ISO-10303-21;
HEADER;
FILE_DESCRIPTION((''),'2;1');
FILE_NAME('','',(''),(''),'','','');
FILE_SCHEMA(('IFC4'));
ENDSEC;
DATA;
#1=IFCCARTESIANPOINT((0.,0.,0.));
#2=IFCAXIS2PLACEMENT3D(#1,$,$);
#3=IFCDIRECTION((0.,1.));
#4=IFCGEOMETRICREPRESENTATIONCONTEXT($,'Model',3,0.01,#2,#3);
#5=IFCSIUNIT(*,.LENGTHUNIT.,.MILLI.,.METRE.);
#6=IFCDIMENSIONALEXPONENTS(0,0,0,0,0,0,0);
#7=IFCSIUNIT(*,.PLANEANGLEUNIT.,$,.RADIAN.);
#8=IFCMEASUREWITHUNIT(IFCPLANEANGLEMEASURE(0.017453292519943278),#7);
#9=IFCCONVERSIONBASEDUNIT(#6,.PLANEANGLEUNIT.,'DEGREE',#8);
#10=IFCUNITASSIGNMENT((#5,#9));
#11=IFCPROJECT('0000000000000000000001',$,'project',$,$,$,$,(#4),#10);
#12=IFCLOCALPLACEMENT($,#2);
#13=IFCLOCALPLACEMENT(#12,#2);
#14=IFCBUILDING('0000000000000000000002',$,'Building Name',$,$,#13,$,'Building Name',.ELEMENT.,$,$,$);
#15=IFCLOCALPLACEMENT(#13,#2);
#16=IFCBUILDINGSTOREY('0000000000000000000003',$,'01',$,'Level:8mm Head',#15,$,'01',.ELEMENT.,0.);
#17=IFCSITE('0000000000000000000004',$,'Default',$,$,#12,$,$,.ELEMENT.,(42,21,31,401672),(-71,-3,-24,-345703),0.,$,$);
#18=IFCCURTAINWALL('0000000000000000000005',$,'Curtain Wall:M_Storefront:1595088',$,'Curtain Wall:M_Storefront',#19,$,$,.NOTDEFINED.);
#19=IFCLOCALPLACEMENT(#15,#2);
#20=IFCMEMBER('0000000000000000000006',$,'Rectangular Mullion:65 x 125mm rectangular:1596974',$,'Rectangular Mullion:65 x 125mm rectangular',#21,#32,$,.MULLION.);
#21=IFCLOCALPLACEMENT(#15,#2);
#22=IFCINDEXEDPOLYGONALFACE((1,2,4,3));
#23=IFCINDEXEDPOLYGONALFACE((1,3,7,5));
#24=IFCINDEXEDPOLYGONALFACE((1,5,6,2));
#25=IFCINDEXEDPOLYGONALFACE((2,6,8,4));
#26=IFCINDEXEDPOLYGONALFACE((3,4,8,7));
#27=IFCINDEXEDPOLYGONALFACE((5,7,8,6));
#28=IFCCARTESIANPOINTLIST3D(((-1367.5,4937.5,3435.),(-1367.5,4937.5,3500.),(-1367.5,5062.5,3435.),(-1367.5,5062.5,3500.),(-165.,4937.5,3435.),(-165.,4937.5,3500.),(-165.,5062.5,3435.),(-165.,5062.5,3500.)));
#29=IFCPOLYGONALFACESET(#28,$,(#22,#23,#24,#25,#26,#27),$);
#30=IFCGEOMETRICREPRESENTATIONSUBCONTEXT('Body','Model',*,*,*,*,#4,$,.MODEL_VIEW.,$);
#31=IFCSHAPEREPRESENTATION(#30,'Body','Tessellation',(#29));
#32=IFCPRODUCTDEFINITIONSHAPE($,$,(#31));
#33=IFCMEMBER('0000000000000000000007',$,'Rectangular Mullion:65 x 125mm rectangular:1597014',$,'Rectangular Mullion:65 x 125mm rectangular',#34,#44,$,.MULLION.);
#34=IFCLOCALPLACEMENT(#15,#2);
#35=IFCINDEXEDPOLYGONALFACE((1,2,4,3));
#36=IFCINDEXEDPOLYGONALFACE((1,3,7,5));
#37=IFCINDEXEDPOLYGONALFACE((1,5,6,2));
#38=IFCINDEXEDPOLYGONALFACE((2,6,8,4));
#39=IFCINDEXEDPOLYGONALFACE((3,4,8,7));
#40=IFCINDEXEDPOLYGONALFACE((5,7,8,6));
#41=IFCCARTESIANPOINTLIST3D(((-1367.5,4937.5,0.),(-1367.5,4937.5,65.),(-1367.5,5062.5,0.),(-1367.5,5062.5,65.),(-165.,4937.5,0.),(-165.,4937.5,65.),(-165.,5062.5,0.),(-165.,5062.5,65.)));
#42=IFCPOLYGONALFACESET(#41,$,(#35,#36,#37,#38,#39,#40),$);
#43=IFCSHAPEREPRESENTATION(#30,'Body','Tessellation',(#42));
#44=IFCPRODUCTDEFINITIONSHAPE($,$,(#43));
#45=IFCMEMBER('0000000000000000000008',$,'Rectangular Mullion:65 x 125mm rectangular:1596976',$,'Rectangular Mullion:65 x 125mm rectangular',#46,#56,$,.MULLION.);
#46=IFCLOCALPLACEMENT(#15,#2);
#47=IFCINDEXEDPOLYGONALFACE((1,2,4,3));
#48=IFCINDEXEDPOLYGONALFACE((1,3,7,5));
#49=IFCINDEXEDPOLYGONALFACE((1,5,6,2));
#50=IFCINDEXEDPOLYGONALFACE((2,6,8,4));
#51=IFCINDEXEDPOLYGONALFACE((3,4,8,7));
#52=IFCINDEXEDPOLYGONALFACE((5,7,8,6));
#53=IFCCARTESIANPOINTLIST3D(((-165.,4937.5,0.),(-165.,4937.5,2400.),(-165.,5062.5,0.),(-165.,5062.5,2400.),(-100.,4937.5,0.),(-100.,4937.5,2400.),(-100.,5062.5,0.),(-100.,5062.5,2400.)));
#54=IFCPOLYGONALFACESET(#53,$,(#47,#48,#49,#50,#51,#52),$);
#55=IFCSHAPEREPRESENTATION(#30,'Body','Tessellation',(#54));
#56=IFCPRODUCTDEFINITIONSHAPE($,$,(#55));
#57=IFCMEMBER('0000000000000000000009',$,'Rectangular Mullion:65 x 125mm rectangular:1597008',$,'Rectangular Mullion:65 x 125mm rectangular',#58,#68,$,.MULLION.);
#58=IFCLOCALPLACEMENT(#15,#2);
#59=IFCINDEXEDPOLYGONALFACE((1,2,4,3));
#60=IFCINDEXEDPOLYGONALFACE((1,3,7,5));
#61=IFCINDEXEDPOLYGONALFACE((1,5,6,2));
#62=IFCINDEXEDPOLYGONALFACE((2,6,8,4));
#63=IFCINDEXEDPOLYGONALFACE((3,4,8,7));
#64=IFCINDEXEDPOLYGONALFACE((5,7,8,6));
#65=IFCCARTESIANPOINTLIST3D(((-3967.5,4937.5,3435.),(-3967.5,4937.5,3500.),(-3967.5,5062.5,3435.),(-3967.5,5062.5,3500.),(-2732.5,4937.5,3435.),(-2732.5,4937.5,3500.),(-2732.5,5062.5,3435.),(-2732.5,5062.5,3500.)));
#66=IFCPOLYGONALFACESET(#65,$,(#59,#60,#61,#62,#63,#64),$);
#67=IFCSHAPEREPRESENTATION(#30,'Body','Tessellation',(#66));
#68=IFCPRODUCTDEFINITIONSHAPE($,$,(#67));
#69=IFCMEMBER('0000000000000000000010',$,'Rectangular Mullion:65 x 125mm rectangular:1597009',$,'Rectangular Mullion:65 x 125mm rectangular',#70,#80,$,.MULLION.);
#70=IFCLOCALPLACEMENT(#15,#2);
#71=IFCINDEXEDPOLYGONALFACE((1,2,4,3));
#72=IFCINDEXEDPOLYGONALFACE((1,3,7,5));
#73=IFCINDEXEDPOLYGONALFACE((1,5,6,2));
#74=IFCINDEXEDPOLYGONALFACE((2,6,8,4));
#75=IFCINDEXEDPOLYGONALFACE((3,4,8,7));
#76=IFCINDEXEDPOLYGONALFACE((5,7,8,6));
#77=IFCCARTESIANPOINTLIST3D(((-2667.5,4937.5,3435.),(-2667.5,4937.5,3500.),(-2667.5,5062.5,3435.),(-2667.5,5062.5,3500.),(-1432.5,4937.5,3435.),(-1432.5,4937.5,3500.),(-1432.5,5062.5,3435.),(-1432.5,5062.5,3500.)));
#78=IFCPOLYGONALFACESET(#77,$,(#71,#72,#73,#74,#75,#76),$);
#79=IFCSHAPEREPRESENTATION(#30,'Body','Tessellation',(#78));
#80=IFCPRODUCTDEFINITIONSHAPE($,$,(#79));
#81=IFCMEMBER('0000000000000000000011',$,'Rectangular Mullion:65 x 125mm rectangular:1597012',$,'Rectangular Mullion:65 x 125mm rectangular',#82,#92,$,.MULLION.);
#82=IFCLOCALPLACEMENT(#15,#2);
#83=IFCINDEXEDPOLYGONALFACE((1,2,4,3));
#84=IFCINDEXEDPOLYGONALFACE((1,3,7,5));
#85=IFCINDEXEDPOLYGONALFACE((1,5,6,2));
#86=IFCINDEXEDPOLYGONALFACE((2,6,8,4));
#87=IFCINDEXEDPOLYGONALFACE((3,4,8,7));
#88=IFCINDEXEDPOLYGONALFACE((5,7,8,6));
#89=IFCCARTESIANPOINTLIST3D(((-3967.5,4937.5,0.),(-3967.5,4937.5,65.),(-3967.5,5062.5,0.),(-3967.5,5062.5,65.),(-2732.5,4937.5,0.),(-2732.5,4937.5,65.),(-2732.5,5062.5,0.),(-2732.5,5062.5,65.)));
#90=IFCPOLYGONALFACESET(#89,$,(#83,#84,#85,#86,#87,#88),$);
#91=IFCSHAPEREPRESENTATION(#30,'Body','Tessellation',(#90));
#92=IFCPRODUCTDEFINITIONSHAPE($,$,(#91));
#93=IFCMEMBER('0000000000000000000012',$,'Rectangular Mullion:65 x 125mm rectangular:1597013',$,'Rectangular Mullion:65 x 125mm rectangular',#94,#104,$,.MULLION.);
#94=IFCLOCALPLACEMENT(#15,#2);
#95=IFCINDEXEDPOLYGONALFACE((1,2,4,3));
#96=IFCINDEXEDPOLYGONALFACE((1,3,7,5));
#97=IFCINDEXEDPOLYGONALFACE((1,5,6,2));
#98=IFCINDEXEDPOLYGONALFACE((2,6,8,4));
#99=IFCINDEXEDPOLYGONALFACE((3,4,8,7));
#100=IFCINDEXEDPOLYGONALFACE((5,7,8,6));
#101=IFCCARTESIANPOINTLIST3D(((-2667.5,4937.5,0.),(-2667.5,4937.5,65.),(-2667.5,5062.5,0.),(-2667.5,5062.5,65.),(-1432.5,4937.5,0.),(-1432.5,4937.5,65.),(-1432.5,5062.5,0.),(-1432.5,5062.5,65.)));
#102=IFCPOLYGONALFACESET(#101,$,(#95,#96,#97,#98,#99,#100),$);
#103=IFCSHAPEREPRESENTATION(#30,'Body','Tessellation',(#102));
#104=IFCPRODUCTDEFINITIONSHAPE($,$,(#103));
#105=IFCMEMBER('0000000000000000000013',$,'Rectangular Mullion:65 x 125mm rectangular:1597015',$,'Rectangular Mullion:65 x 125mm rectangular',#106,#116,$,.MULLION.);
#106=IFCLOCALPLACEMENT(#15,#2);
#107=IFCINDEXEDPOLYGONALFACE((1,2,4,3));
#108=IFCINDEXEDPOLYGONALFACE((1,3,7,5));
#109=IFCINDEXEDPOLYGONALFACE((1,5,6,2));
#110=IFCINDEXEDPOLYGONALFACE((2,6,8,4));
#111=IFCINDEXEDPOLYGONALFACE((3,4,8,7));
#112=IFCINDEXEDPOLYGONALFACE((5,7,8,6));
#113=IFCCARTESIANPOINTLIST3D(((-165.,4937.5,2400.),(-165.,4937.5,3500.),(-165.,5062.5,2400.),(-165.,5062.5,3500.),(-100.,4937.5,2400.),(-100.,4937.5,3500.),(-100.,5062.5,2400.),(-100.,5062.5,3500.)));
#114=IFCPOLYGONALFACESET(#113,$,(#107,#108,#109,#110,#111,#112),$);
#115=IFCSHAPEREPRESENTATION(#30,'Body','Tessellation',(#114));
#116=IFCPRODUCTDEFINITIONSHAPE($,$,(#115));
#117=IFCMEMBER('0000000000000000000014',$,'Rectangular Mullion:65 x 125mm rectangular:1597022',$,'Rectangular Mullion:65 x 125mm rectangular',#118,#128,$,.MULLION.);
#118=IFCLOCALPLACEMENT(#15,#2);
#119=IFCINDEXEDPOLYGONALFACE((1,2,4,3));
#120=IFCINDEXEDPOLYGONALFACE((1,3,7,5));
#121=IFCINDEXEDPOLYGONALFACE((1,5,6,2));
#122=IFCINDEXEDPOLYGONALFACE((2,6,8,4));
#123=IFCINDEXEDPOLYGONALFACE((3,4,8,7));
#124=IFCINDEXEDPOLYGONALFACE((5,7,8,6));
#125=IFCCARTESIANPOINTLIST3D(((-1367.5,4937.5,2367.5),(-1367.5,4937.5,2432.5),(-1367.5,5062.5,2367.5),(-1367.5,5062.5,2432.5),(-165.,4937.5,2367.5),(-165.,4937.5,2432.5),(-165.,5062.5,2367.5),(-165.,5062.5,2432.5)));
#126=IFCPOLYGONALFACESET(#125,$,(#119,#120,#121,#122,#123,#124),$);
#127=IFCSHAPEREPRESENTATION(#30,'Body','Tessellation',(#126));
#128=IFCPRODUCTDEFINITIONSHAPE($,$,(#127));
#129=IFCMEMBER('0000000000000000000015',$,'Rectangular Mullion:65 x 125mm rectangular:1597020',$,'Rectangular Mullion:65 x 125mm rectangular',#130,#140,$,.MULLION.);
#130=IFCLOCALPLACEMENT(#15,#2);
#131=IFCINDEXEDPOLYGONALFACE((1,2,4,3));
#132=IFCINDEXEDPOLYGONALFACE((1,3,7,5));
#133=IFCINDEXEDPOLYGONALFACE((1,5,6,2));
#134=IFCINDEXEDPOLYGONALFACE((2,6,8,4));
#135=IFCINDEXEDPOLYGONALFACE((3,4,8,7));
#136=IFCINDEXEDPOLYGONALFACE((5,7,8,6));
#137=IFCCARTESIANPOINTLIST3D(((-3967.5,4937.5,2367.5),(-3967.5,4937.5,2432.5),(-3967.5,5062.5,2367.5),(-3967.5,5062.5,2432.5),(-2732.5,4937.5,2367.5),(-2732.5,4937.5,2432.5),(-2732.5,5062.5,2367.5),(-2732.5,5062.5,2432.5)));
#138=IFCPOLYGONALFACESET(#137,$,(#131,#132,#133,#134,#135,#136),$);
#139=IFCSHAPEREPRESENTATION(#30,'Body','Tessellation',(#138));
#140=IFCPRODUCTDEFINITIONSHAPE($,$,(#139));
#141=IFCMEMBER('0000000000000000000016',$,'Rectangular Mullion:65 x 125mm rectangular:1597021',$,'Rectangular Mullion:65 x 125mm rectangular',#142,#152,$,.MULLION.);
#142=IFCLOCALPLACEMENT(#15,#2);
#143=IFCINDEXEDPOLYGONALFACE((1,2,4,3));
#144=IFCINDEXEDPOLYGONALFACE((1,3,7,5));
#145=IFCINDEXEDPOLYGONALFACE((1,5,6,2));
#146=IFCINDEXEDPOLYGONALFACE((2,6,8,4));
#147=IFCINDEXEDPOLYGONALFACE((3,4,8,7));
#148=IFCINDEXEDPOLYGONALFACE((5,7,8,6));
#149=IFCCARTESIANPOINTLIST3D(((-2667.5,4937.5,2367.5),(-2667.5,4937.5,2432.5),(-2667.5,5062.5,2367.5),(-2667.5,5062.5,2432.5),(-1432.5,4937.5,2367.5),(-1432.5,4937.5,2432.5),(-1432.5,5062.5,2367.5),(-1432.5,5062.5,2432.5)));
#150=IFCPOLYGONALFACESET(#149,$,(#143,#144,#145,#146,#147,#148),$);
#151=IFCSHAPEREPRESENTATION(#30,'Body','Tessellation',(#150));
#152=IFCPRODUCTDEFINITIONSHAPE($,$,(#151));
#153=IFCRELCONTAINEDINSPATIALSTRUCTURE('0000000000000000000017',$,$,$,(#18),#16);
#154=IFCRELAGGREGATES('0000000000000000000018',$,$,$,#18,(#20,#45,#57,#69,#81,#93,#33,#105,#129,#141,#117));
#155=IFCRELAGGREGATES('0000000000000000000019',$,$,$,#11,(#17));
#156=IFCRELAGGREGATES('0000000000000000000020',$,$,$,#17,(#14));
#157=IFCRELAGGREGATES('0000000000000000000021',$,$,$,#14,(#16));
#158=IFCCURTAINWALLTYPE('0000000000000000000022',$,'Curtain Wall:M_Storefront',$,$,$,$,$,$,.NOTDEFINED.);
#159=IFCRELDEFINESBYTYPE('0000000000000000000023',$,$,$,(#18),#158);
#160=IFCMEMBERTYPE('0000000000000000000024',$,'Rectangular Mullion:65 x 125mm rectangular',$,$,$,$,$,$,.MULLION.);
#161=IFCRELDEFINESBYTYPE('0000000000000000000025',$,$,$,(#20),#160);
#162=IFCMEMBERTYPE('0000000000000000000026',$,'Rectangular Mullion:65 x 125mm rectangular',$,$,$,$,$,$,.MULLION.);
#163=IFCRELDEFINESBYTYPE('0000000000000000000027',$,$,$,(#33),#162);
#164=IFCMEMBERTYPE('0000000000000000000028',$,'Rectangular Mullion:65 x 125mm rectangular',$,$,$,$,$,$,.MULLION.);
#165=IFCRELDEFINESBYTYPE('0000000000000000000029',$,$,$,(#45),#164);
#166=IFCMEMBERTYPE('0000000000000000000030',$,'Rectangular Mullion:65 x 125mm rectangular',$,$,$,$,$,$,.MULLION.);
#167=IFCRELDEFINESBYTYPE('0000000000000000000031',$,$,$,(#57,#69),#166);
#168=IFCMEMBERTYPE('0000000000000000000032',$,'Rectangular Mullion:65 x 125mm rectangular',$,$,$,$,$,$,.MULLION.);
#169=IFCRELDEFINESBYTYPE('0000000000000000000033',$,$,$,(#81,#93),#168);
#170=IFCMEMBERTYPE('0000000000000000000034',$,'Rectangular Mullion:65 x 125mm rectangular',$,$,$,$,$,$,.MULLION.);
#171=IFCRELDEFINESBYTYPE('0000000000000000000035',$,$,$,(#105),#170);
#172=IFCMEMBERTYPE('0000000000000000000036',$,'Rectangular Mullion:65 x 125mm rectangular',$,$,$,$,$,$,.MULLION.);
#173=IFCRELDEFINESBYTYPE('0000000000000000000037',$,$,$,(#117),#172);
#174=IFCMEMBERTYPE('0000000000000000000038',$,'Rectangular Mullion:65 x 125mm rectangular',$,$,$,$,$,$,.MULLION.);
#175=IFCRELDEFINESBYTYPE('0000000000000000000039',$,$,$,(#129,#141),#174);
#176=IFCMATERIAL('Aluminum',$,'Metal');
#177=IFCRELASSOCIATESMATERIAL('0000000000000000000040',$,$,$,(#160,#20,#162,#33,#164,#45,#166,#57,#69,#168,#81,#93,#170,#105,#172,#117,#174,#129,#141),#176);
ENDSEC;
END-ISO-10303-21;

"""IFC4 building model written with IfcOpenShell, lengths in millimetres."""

from ifc_helpers import new_model, entity, si_unit, converted_unit, direction, frame, origin, place, context, subcontext, project, spatial, indexed_curve, outline, extrude, source, transform, mapped, material, type_object, type_shapes, element, aggregate, save


model = new_model("IFC4")

# Units and contexts
model_context = context("Model", 3, precision=0.01, world=origin(), true_north=direction((0.0, 1.0)))
body_context = subcontext(model_context, "Body", "Model", "MODEL_VIEW")
ifc_project = project(units=[si_unit("LENGTHUNIT", "METRE", prefix="MILLI"), converted_unit("PLANEANGLEUNIT", "DEGREE", entity("IfcPlaneAngleMeasure", 0.017453292519943278), si_unit("PLANEANGLEUNIT", "RADIAN"), dimensions=[0, 0, 0, 0, 0, 0, 0])], contexts=[model_context])

# Site, building, storey
site_placement = place(None, origin())
site = spatial("IfcSite", under=ifc_project, at=site_placement, Name="Default", CompositionType="ELEMENT", RefLatitude=(42, 21, 31, 401672), RefLongitude=(-71, -3, -24, -345703), RefElevation=0.0)
building_placement = place(site_placement, origin())
building = spatial("IfcBuilding", under=site, at=building_placement, Name="Building Name", LongName="Building Name", CompositionType="ELEMENT")
storey_placement = place(building_placement, origin())
storey = spatial("IfcBuildingStorey", under=building, at=storey_placement, Name="01", ObjectType="Level:8mm Head", LongName="01", CompositionType="ELEMENT", Elevation=0.0)

# Curtain wall, members
curtain_wall_type = type_object("IfcCurtainWallType", Name="Curtain Wall:M_Storefront", PredefinedType="NOTDEFINED")
curtain_wall_placement = place(storey_placement, origin())
curtain_wall = element("IfcCurtainWall", 1, at=curtain_wall_placement, inside=storey, type_object=curtain_wall_type, Name="Curtain Wall:M_Storefront:1595088", ObjectType="Curtain Wall:M_Storefront", PredefinedType="NOTDEFINED")
ifc_material_1 = material(Name="Aluminum", Category="Metal")
member_type_1 = type_object("IfcMemberType", Name="Rectangular Mullion:65 x 125mm rectangular", PredefinedType="MULLION", material=ifc_material_1)
shared_shape_1 = source(origin(), body_context, "Body", "SweptSolid", [
    extrude(outline(indexed_curve([(-32.5, -62.5), (32.5, -62.5), (32.5, 62.5), (-32.5, 62.5), (-32.5, -62.5)], self_intersect=False)), frame((-32.5, 0.0, -1202.5), z_axis=(0.0, 0.0, 1.0), x_axis=(-1.0, 0.0, 0.0)), (0.0, 0.0, 1.0), 1202.5),
])
type_shapes(member_type_1, [shared_shape_1])
member_1_placement = place(curtain_wall_placement, frame((-165.0, 5000.0, 3500.0), z_axis=(1.0, 0.0, 0.0), x_axis=(0.0, 0.0, 1.0)))
member_1 = element("IfcMember", 2, at=member_1_placement, type_object=member_type_1, material=ifc_material_1, Name="Rectangular Mullion:65 x 125mm rectangular:1596974", ObjectType="Rectangular Mullion:65 x 125mm rectangular", PredefinedType="MULLION", context=body_context, shape_type="MappedRepresentation", body=[
    mapped(shared_shape_1, transform((0.0, 0.0, 0.0), scale=1.0)),
])
member_type_2 = type_object("IfcMemberType", Name="Rectangular Mullion:65 x 125mm rectangular", PredefinedType="MULLION", material=ifc_material_1)
shared_shape_2 = source(origin(), body_context, "Body", "SweptSolid", [
    extrude(outline(indexed_curve([(-32.5, -62.5), (32.5, -62.5), (32.5, 62.5), (-32.5, 62.5), (-32.5, -62.5)], self_intersect=False)), frame((-32.5, 0.0, -1202.5), z_axis=(0.0, 0.0, 1.0), x_axis=(-1.0, 0.0, 0.0)), (0.0, 0.0, 1.0), 1202.5),
])
type_shapes(member_type_2, [shared_shape_2])
member_2_placement = place(curtain_wall_placement, frame((-1367.5, 5000.0, 0.0), z_axis=(-1.0, 0.0, 0.0), x_axis=(0.0, 0.0, -1.0)))
member_2 = element("IfcMember", 3, at=member_2_placement, type_object=member_type_2, material=ifc_material_1, Name="Rectangular Mullion:65 x 125mm rectangular:1597014", ObjectType="Rectangular Mullion:65 x 125mm rectangular", PredefinedType="MULLION", context=body_context, shape_type="MappedRepresentation", body=[
    mapped(shared_shape_2, transform((0.0, 0.0, 0.0), scale=1.0)),
])
member_type_3 = type_object("IfcMemberType", Name="Rectangular Mullion:65 x 125mm rectangular", PredefinedType="MULLION", material=ifc_material_1)
shared_shape_3 = source(origin(), body_context, "Body", "SweptSolid", [
    extrude(outline(indexed_curve([(-32.5, -62.5), (32.5, -62.5), (32.5, 62.5), (-32.5, 62.5), (-32.5, -62.5)], self_intersect=False)), frame((-32.5, 0.0, -2400.0), z_axis=(0.0, 0.0, 1.0), x_axis=(-1.0, 0.0, 0.0)), (0.0, 0.0, 1.0), 2400.0),
])
type_shapes(member_type_3, [shared_shape_3])
member_3_placement = place(curtain_wall_placement, frame((-100.0, 5000.0, 0.0), z_axis=(0.0, 0.0, -1.0), x_axis=(1.0, 0.0, 0.0)))
member_3 = element("IfcMember", 4, at=member_3_placement, type_object=member_type_3, material=ifc_material_1, Name="Rectangular Mullion:65 x 125mm rectangular:1596976", ObjectType="Rectangular Mullion:65 x 125mm rectangular", PredefinedType="MULLION", context=body_context, shape_type="MappedRepresentation", body=[
    mapped(shared_shape_3, transform((0.0, 0.0, 0.0), scale=1.0)),
])
member_type_4 = type_object("IfcMemberType", Name="Rectangular Mullion:65 x 125mm rectangular", PredefinedType="MULLION", material=ifc_material_1)
shared_shape_4 = source(origin(), body_context, "Body", "SweptSolid", [
    extrude(outline(indexed_curve([(-32.5, -62.5), (32.5, -62.5), (32.5, 62.5), (-32.5, 62.5), (-32.5, -62.5)], self_intersect=False)), frame((-32.5, 0.0, -1235.0), z_axis=(0.0, 0.0, 1.0), x_axis=(-1.0, 0.0, 0.0)), (0.0, 0.0, 1.0), 1235.0),
])
type_shapes(member_type_4, [shared_shape_4])
member_4_placement = place(curtain_wall_placement, frame((-2732.5, 5000.0, 3500.0), z_axis=(1.0, 0.0, 0.0), x_axis=(0.0, 0.0, 1.0)))
member_4 = element("IfcMember", 5, at=member_4_placement, type_object=member_type_4, material=ifc_material_1, Name="Rectangular Mullion:65 x 125mm rectangular:1597008", ObjectType="Rectangular Mullion:65 x 125mm rectangular", PredefinedType="MULLION", context=body_context, shape_type="MappedRepresentation", body=[
    mapped(shared_shape_4, transform((0.0, 0.0, 0.0), scale=1.0)),
])
member_5_placement = place(curtain_wall_placement, frame((-1432.5, 5000.0, 3500.0), z_axis=(1.0, 0.0, 0.0), x_axis=(0.0, 0.0, 1.0)))
member_5 = element("IfcMember", 6, at=member_5_placement, type_object=member_type_4, material=ifc_material_1, Name="Rectangular Mullion:65 x 125mm rectangular:1597009", ObjectType="Rectangular Mullion:65 x 125mm rectangular", PredefinedType="MULLION", context=body_context, shape_type="MappedRepresentation", body=[
    mapped(shared_shape_4, transform((0.0, 0.0, 0.0), scale=1.0)),
])
member_type_5 = type_object("IfcMemberType", Name="Rectangular Mullion:65 x 125mm rectangular", PredefinedType="MULLION", material=ifc_material_1)
shared_shape_5 = source(origin(), body_context, "Body", "SweptSolid", [
    extrude(outline(indexed_curve([(-32.5, -62.5), (32.5, -62.5), (32.5, 62.5), (-32.5, 62.5), (-32.5, -62.5)], self_intersect=False)), frame((-32.5, 0.0, -1235.0), z_axis=(0.0, 0.0, 1.0), x_axis=(-1.0, 0.0, 0.0)), (0.0, 0.0, 1.0), 1235.0),
])
type_shapes(member_type_5, [shared_shape_5])
member_6_placement = place(curtain_wall_placement, frame((-3967.5, 5000.0, 0.0), z_axis=(-1.0, 0.0, 0.0), x_axis=(0.0, 0.0, -1.0)))
member_6 = element("IfcMember", 7, at=member_6_placement, type_object=member_type_5, material=ifc_material_1, Name="Rectangular Mullion:65 x 125mm rectangular:1597012", ObjectType="Rectangular Mullion:65 x 125mm rectangular", PredefinedType="MULLION", context=body_context, shape_type="MappedRepresentation", body=[
    mapped(shared_shape_5, transform((0.0, 0.0, 0.0), scale=1.0)),
])
member_7_placement = place(curtain_wall_placement, frame((-2667.5, 5000.0, 0.0), z_axis=(-1.0, 0.0, 0.0), x_axis=(0.0, 0.0, -1.0)))
member_7 = element("IfcMember", 8, at=member_7_placement, type_object=member_type_5, material=ifc_material_1, Name="Rectangular Mullion:65 x 125mm rectangular:1597013", ObjectType="Rectangular Mullion:65 x 125mm rectangular", PredefinedType="MULLION", context=body_context, shape_type="MappedRepresentation", body=[
    mapped(shared_shape_5, transform((0.0, 0.0, 0.0), scale=1.0)),
])
member_type_6 = type_object("IfcMemberType", Name="Rectangular Mullion:65 x 125mm rectangular", PredefinedType="MULLION", material=ifc_material_1)
shared_shape_6 = source(origin(), body_context, "Body", "SweptSolid", [
    extrude(outline(indexed_curve([(-32.5, -62.5), (32.5, -62.5), (32.5, 62.5), (-32.5, 62.5), (-32.5, -62.5)], self_intersect=False)), frame((-32.5, 0.0, -1100.0), z_axis=(0.0, 0.0, 1.0), x_axis=(-1.0, 0.0, 0.0)), (0.0, 0.0, 1.0), 1100.0),
])
type_shapes(member_type_6, [shared_shape_6])
member_8_placement = place(curtain_wall_placement, frame((-100.0, 5000.0, 2400.0), z_axis=(0.0, 0.0, -1.0), x_axis=(1.0, 0.0, 0.0)))
member_8 = element("IfcMember", 9, at=member_8_placement, type_object=member_type_6, material=ifc_material_1, Name="Rectangular Mullion:65 x 125mm rectangular:1597015", ObjectType="Rectangular Mullion:65 x 125mm rectangular", PredefinedType="MULLION", context=body_context, shape_type="MappedRepresentation", body=[
    mapped(shared_shape_6, transform((0.0, 0.0, 0.0), scale=1.0)),
])
member_type_7 = type_object("IfcMemberType", Name="Rectangular Mullion:65 x 125mm rectangular", PredefinedType="MULLION", material=ifc_material_1)
shared_shape_7 = source(origin(), body_context, "Body", "SweptSolid", [
    extrude(outline(indexed_curve([(-32.5, -62.5), (32.5, -62.5), (32.5, 62.5), (-32.5, 62.5), (-32.5, -62.5)], self_intersect=False)), frame((0.0, 0.0, -1202.5), z_axis=(0.0, 0.0, 1.0), x_axis=(-1.0, 0.0, 0.0)), (0.0, 0.0, 1.0), 1202.5),
])
type_shapes(member_type_7, [shared_shape_7])
member_9_placement = place(curtain_wall_placement, frame((-165.0, 5000.0, 2400.0), z_axis=(1.0, 0.0, 0.0), x_axis=(0.0, 0.0, 1.0)))
member_9 = element("IfcMember", 10, at=member_9_placement, type_object=member_type_7, material=ifc_material_1, Name="Rectangular Mullion:65 x 125mm rectangular:1597022", ObjectType="Rectangular Mullion:65 x 125mm rectangular", PredefinedType="MULLION", context=body_context, shape_type="MappedRepresentation", body=[
    mapped(shared_shape_7, transform((0.0, 0.0, 0.0), scale=1.0)),
])
member_type_8 = type_object("IfcMemberType", Name="Rectangular Mullion:65 x 125mm rectangular", PredefinedType="MULLION", material=ifc_material_1)
shared_shape_8 = source(origin(), body_context, "Body", "SweptSolid", [
    extrude(outline(indexed_curve([(-32.5, -62.5), (32.5, -62.5), (32.5, 62.5), (-32.5, 62.5), (-32.5, -62.5)], self_intersect=False)), frame((0.0, 0.0, -1235.0), z_axis=(0.0, 0.0, 1.0), x_axis=(-1.0, 0.0, 0.0)), (0.0, 0.0, 1.0), 1235.0),
])
type_shapes(member_type_8, [shared_shape_8])
member_10_placement = place(curtain_wall_placement, frame((-2732.5, 5000.0, 2400.0), z_axis=(1.0, 0.0, 0.0), x_axis=(0.0, 0.0, 1.0)))
member_10 = element("IfcMember", 11, at=member_10_placement, type_object=member_type_8, material=ifc_material_1, Name="Rectangular Mullion:65 x 125mm rectangular:1597020", ObjectType="Rectangular Mullion:65 x 125mm rectangular", PredefinedType="MULLION", context=body_context, shape_type="MappedRepresentation", body=[
    mapped(shared_shape_8, transform((0.0, 0.0, 0.0), scale=1.0)),
])
member_11_placement = place(curtain_wall_placement, frame((-1432.5, 5000.0, 2400.0), z_axis=(1.0, 0.0, 0.0), x_axis=(0.0, 0.0, 1.0)))
member_11 = element("IfcMember", 12, at=member_11_placement, type_object=member_type_8, material=ifc_material_1, Name="Rectangular Mullion:65 x 125mm rectangular:1597021", ObjectType="Rectangular Mullion:65 x 125mm rectangular", PredefinedType="MULLION", context=body_context, shape_type="MappedRepresentation", body=[
    mapped(shared_shape_8, transform((0.0, 0.0, 0.0), scale=1.0)),
])
aggregate(curtain_wall, [member_1, member_3, member_4, member_5, member_6, member_7, member_2, member_8, member_10, member_11, member_9])

save(model, "model.ifc")
